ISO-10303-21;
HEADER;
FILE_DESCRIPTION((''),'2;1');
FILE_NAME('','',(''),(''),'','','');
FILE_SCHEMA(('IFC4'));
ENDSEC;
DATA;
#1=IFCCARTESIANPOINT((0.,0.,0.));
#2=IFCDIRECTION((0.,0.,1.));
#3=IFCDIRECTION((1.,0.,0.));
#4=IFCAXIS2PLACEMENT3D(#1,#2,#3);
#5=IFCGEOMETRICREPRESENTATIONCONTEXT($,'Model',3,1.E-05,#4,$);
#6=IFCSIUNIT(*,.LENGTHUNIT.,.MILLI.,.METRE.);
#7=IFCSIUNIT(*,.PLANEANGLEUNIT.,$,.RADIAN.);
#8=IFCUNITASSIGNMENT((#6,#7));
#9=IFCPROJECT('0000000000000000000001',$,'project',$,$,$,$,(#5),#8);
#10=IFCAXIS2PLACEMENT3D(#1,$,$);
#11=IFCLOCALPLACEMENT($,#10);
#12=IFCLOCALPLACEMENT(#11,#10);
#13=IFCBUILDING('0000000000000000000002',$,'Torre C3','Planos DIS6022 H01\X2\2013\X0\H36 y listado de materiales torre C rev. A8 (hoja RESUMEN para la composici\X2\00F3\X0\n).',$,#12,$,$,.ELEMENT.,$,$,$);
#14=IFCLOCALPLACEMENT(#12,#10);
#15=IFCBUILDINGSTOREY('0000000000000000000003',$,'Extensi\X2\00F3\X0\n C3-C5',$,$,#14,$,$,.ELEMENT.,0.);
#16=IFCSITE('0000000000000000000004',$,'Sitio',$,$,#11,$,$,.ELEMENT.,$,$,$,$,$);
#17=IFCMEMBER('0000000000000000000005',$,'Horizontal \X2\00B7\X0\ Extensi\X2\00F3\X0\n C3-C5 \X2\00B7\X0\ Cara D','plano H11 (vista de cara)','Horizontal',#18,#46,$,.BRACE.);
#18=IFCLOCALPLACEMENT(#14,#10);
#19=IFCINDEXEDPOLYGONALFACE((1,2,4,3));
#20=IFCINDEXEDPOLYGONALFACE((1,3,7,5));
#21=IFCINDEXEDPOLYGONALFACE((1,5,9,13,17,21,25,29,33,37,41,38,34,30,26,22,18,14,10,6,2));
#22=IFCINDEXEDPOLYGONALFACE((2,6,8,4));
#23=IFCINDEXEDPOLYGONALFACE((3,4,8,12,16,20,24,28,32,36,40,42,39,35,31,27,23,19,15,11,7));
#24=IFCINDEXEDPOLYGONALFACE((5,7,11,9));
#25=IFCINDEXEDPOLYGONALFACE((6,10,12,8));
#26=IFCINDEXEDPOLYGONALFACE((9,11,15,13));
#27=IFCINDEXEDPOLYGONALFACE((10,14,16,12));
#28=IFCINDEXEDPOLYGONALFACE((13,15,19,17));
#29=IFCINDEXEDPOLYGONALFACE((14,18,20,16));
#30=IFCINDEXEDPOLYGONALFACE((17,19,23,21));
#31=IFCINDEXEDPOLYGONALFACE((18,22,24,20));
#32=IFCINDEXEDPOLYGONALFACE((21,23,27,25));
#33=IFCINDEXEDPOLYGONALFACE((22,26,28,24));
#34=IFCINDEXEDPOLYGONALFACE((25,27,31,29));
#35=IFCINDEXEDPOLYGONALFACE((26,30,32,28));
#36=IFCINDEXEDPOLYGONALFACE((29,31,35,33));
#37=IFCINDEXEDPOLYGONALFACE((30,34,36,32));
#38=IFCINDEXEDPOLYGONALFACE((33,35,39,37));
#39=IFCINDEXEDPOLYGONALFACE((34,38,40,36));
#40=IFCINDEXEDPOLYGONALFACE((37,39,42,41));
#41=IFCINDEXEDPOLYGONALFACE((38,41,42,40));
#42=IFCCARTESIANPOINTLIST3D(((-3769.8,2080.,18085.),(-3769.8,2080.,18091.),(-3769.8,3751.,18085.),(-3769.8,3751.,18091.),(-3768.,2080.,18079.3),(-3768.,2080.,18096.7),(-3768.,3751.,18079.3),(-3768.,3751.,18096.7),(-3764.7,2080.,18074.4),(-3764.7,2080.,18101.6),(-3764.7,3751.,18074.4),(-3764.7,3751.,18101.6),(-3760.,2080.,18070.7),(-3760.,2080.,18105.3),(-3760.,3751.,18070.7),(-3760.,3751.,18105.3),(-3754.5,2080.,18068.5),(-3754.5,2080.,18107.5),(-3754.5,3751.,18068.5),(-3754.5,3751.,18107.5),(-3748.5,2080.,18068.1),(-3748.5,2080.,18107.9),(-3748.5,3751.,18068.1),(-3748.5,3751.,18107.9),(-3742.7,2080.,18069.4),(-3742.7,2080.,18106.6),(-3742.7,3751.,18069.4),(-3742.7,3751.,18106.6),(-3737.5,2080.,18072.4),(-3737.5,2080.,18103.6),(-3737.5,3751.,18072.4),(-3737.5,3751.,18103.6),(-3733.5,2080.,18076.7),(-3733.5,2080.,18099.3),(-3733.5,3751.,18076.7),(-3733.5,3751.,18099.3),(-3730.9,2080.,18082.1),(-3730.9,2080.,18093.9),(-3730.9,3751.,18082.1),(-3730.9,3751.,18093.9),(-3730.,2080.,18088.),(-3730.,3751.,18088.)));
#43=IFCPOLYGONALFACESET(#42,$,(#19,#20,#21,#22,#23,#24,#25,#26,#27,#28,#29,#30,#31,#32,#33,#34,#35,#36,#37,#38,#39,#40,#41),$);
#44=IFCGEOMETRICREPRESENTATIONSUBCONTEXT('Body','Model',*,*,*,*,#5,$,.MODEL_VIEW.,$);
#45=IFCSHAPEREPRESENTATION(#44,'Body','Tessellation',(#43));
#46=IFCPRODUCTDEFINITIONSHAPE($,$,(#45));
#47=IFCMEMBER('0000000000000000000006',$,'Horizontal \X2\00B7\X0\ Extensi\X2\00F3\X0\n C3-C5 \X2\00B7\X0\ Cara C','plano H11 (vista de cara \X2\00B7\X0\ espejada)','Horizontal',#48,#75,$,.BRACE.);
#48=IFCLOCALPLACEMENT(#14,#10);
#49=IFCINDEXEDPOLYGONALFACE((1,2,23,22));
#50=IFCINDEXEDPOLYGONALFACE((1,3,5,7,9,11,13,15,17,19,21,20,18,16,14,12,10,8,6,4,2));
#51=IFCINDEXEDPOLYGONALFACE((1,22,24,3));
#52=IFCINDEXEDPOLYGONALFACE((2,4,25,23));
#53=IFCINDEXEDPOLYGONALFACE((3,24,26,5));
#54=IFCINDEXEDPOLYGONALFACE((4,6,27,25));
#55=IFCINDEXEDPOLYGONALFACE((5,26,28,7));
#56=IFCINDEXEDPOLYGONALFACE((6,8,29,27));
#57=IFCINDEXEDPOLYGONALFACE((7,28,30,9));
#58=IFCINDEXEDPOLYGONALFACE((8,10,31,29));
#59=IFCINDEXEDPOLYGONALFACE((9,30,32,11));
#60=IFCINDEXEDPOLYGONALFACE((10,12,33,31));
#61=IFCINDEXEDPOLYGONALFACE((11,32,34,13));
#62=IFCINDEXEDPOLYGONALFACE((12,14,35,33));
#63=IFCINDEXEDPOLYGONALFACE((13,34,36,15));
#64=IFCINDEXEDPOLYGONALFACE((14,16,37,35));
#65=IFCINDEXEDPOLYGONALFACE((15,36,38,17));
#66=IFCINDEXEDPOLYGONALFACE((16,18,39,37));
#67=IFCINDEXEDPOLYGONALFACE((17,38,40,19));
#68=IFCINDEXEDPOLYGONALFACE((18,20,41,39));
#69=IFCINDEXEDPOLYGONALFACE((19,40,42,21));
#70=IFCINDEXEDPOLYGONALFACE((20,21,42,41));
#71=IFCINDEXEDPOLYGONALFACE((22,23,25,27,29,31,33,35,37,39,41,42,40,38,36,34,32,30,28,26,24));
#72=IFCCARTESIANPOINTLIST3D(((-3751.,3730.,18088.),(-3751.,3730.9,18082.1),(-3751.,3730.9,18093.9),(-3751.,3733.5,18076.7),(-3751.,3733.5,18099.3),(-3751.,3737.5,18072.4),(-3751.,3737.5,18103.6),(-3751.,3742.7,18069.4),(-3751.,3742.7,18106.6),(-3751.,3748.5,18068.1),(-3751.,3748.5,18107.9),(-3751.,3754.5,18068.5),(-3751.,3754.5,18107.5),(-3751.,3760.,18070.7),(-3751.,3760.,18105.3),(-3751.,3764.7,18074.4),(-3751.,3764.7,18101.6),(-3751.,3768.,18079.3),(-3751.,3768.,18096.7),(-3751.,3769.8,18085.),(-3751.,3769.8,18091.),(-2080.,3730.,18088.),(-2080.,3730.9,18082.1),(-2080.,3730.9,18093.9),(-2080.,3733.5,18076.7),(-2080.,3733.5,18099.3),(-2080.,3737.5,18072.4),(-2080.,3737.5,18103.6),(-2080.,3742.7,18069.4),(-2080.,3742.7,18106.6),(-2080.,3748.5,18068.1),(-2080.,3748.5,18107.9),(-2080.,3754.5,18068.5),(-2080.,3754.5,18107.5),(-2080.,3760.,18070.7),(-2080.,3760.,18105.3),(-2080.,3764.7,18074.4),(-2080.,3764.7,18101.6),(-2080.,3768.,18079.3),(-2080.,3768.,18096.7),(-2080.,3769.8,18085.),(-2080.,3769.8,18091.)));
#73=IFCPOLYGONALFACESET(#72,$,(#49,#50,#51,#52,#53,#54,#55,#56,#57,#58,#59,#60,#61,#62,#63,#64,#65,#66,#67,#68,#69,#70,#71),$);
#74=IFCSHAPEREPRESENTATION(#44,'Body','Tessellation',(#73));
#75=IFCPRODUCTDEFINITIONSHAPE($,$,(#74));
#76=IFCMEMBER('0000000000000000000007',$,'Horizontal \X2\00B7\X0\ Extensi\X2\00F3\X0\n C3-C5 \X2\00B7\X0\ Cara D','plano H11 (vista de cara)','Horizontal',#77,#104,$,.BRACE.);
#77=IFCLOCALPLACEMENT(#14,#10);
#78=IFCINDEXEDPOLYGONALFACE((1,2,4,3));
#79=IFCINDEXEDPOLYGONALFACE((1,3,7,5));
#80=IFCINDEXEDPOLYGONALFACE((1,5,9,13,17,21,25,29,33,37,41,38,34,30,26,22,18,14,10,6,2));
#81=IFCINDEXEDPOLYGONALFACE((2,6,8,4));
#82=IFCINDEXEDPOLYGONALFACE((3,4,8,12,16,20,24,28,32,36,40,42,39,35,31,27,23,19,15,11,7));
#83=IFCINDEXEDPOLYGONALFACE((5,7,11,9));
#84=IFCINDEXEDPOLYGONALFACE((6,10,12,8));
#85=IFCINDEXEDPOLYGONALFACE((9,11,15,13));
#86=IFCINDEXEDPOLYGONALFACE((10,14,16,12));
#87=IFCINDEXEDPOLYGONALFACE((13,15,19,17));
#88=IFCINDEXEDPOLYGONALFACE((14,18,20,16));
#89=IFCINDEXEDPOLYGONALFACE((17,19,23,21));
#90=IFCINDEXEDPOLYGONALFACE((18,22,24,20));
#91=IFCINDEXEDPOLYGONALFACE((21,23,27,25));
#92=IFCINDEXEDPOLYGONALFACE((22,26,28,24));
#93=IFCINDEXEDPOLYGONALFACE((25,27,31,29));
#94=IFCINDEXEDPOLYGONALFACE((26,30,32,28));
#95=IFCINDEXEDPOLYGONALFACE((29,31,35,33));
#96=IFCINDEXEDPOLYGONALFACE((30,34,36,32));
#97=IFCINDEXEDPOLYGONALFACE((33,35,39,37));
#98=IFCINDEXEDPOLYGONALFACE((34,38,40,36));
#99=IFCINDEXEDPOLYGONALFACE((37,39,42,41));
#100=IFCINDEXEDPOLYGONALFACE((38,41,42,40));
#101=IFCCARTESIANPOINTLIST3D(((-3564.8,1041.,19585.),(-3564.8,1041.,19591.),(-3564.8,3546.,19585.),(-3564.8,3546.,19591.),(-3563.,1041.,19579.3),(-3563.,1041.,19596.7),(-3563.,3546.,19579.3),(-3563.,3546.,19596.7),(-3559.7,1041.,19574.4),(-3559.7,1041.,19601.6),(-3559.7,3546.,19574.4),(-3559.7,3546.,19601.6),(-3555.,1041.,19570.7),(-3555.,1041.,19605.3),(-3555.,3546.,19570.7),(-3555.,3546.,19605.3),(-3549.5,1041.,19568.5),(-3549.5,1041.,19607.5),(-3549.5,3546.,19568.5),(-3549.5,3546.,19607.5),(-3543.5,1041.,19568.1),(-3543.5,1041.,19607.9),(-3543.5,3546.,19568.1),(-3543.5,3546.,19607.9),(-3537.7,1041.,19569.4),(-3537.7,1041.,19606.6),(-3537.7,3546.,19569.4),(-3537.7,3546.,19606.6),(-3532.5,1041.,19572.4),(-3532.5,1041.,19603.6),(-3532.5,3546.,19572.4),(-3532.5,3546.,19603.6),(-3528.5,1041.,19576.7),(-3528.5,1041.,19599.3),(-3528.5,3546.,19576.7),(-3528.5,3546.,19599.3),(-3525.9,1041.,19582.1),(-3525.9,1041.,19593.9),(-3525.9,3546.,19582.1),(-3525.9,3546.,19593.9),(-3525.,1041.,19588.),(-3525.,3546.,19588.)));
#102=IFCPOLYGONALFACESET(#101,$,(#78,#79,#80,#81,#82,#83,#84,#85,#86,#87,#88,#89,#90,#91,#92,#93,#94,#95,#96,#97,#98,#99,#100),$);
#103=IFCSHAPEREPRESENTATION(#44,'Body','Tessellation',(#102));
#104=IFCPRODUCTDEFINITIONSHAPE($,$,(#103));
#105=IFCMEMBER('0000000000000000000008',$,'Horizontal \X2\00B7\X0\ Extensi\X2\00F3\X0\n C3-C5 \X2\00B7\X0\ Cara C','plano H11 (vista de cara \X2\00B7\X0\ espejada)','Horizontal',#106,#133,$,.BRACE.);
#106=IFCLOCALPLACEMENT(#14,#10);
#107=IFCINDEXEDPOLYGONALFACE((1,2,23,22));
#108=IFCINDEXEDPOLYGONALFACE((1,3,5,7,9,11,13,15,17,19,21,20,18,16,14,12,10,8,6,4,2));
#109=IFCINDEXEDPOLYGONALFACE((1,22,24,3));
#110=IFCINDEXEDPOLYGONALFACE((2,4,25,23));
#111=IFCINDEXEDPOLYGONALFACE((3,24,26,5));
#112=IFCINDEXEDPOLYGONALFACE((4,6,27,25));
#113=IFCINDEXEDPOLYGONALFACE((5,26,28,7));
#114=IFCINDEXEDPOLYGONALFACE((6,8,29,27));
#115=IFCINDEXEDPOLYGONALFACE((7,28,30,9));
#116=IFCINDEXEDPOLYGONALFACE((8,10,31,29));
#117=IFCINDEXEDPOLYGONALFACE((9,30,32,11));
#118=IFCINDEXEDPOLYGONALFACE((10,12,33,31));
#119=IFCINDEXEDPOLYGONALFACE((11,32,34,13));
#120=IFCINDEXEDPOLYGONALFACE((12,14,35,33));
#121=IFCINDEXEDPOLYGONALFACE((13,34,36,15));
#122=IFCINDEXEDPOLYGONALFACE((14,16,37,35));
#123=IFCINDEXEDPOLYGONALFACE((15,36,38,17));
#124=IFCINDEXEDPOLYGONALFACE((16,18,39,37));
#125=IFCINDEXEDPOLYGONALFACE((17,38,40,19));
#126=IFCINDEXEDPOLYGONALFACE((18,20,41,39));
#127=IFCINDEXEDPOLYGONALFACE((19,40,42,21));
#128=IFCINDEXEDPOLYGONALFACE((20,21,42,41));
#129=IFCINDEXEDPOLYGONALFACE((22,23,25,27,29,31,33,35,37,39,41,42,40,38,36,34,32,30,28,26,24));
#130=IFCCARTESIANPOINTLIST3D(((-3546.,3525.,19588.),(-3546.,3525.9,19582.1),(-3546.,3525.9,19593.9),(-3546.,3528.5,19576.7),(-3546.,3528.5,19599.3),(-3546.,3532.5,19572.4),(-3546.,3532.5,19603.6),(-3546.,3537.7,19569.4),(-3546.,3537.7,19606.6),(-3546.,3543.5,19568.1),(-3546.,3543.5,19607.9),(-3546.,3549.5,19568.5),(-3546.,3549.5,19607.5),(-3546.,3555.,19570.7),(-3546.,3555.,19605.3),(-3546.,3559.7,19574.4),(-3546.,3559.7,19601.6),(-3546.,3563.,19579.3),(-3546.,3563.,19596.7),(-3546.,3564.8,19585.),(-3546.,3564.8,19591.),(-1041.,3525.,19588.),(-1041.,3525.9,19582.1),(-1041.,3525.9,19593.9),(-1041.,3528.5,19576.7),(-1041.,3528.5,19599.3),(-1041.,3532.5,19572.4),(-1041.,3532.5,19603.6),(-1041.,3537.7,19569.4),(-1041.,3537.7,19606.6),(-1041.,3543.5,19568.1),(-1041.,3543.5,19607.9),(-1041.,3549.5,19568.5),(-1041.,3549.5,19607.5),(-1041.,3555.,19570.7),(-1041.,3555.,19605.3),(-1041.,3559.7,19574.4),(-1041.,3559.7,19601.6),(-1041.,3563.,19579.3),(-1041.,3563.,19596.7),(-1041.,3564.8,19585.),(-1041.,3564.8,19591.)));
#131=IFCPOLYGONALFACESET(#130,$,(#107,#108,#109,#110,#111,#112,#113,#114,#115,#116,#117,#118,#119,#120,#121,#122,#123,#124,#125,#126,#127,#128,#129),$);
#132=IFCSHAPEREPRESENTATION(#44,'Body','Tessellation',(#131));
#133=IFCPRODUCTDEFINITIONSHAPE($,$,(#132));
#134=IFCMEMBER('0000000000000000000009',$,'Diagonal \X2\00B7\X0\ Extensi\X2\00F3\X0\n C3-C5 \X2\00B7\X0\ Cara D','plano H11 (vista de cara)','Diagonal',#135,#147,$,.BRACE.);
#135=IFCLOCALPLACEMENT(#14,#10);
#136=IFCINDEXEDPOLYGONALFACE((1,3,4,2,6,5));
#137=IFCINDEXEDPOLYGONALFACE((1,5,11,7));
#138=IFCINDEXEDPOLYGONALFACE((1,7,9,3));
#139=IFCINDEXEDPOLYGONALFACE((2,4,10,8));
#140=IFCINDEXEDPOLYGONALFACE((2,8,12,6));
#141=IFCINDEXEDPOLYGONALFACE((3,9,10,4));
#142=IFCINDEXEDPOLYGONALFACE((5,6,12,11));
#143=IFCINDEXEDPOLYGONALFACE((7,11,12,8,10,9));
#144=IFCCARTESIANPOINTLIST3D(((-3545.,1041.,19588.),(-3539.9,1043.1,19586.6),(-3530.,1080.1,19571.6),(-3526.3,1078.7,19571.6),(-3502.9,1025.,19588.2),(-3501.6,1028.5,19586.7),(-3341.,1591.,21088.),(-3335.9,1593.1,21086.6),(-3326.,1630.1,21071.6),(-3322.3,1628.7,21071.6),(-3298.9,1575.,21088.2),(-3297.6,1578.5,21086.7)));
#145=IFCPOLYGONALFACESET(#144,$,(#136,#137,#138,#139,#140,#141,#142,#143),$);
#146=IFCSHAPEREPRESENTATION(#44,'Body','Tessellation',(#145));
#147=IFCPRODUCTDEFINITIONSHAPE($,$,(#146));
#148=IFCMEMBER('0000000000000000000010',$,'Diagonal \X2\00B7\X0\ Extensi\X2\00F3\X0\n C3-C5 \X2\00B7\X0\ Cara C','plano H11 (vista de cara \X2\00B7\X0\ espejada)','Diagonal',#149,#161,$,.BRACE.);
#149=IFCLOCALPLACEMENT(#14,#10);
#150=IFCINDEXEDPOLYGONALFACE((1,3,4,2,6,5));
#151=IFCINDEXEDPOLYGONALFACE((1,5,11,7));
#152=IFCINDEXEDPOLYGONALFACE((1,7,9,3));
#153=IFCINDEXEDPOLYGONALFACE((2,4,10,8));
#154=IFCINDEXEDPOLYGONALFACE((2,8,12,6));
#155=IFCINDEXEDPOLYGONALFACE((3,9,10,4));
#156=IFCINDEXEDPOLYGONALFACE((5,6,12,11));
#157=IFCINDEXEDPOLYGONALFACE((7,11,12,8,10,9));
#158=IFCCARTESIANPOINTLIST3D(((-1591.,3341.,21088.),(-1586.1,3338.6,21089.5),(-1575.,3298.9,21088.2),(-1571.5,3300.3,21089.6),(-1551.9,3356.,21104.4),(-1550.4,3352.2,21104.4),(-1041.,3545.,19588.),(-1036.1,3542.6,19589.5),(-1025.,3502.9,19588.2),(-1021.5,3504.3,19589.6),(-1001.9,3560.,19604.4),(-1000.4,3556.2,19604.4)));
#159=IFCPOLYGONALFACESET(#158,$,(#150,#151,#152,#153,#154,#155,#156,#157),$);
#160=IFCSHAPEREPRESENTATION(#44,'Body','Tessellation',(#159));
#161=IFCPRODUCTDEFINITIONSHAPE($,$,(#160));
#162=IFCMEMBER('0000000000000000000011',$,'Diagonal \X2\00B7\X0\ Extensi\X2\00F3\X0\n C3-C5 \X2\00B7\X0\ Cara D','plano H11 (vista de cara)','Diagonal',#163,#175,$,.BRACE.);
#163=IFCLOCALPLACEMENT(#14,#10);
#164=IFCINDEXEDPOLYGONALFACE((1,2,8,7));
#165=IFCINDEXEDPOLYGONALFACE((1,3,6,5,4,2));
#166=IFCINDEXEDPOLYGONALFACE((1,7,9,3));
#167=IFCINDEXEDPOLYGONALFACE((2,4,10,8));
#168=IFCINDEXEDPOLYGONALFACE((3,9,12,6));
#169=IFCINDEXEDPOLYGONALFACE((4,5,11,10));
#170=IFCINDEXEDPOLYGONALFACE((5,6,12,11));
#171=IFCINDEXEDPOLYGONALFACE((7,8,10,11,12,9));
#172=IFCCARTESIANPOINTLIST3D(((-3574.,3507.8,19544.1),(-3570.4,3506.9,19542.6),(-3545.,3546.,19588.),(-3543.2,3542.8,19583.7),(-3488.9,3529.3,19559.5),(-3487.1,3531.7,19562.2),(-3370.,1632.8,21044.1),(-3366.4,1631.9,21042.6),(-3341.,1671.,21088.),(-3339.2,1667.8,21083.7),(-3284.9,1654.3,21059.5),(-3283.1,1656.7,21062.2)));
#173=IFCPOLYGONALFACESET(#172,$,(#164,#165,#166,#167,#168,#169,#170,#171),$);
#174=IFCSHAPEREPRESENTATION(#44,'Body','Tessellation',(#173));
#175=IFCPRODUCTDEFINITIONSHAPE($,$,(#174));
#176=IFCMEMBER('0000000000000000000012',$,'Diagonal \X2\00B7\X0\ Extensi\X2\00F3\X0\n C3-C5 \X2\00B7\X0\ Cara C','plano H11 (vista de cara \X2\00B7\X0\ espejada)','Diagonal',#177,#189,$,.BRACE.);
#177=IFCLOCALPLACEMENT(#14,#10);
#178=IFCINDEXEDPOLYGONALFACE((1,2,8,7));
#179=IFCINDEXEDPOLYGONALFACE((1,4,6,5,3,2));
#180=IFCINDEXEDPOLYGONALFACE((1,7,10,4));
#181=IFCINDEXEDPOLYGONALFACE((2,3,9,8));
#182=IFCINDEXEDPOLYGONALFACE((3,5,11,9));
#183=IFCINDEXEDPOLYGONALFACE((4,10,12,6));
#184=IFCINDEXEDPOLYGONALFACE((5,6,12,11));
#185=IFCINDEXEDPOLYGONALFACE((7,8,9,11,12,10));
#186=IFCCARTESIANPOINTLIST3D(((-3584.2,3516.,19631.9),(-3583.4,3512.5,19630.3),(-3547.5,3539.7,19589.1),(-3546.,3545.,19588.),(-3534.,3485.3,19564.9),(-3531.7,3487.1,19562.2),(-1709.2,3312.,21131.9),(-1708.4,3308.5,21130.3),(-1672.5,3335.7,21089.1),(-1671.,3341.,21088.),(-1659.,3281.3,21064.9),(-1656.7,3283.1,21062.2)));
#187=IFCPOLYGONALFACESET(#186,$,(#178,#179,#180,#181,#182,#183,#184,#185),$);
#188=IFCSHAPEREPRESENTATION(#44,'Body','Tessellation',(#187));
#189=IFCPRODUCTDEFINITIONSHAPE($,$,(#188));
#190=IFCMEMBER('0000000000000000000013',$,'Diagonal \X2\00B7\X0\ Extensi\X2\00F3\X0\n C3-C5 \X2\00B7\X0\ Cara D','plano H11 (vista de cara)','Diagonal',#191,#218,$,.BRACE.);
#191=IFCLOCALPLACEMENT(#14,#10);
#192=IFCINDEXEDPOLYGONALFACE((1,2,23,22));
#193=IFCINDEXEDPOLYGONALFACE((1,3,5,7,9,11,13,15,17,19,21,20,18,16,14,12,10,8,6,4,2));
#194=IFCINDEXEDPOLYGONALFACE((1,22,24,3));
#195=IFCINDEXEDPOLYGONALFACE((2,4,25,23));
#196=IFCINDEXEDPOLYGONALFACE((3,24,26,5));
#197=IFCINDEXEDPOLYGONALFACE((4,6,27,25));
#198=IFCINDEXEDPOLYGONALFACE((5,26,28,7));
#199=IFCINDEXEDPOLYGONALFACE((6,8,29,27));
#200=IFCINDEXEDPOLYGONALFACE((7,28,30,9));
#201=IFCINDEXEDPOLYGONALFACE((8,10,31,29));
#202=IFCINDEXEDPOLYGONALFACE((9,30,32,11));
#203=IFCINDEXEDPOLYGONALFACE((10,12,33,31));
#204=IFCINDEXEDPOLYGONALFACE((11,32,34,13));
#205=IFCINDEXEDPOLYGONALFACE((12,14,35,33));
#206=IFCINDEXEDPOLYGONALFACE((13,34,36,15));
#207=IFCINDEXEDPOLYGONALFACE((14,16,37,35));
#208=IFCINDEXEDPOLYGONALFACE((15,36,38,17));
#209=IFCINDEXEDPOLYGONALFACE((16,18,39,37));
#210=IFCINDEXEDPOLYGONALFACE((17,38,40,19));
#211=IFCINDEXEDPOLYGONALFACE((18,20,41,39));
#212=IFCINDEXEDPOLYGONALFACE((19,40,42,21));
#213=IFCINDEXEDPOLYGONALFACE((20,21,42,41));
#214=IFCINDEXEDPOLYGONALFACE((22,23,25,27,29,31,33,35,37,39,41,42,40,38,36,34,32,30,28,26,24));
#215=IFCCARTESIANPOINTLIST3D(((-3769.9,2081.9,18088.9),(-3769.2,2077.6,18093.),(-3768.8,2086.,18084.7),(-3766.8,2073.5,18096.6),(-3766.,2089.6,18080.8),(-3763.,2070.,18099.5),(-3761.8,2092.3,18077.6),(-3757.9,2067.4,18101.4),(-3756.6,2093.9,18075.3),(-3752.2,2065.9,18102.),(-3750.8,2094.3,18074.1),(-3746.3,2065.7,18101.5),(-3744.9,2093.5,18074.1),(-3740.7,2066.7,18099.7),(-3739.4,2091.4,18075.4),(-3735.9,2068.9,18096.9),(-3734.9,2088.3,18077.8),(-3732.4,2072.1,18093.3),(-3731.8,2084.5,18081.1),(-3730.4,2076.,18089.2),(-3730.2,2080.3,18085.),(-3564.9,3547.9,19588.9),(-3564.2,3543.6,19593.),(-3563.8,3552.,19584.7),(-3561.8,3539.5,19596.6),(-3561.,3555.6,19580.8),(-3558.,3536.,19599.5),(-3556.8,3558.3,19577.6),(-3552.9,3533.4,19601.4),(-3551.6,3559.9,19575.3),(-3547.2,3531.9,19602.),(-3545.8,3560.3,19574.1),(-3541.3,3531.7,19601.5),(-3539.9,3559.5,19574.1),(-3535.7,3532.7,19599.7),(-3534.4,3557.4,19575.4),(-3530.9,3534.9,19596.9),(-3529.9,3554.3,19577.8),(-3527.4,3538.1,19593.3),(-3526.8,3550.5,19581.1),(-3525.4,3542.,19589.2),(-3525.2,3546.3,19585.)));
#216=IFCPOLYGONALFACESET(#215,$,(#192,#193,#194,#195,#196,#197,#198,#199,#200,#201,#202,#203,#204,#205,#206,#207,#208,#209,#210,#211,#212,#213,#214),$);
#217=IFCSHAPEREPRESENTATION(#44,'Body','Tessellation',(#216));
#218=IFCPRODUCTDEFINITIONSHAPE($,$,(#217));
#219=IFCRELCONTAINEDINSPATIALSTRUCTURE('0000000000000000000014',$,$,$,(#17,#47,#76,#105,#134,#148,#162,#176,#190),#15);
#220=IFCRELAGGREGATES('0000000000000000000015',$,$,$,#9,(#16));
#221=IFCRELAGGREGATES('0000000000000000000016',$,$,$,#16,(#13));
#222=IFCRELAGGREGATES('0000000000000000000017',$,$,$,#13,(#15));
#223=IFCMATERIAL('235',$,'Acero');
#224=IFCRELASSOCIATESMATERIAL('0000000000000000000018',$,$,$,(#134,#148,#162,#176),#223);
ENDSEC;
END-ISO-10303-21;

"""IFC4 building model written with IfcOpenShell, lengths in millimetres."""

from ifc_helpers import new_model, si_unit, frame, frame_2d, origin, origin_with_axes, place, context, subcontext, project, spatial, circle, l_section, extrude, material, element, save


model = new_model("IFC4")

# Units and contexts
model_context = context("Model", 3, precision=1e-05, world=origin_with_axes())
body_context = subcontext(model_context, "Body", "Model", "MODEL_VIEW")
ifc_project = project(units=[si_unit("LENGTHUNIT", "METRE", prefix="MILLI"), si_unit("PLANEANGLEUNIT", "RADIAN")], contexts=[model_context])

# Site, building, storey
site_placement = place(None, origin())
site = spatial("IfcSite", under=ifc_project, at=site_placement, Name="Sitio", CompositionType="ELEMENT")
building_placement = place(site_placement, origin())
building = spatial("IfcBuilding", under=site, at=building_placement, Name="Torre C3", Description="Planos DIS6022 H01–H36 y listado de materiales torre C rev. A8 (hoja RESUMEN para la composición).", CompositionType="ELEMENT")
storey_placement = place(building_placement, origin())
storey = spatial("IfcBuildingStorey", under=building, at=storey_placement, Name="Extensión C3-C5", CompositionType="ELEMENT", Elevation=0.0)

# Members
for number, where, z_axis, x_axis, name, description in (
    (1, (-3750.0, 2080.0, 18088.0), (0.0, 1.0, 0.0), (1.0, 0.0, 0.0), "Horizontal · Extensión C3-C5 · Cara D", "plano H11 (vista de cara)"),
    (2, (-2080.0, 3750.0, 18088.0), (-1.0, 0.0, 0.0), (0.0, -1.0, 0.0), "Horizontal · Extensión C3-C5 · Cara C", "plano H11 (vista de cara · espejada)"),
):
    element("IfcMember", number, at=place(storey_placement, frame(where, z_axis=z_axis, x_axis=x_axis)), inside=storey, Name=name, Description=description, ObjectType="Horizontal", PredefinedType="BRACE", context=body_context, shape_type="SweptSolid", body=[
        extrude(circle(Radius=20.0), None, (0.0, 0.0, 1.0), 1671.0),
    ])
for number, where, z_axis, x_axis, name, description in (
    (3, (-3545.0, 1041.0, 19588.0), (0.0, 1.0, 0.0), (1.0, 0.0, 0.0), "Horizontal · Extensión C3-C5 · Cara D", "plano H11 (vista de cara)"),
    (4, (-1041.0, 3545.0, 19588.0), (-1.0, 0.0, 0.0), (0.0, -1.0, 0.0), "Horizontal · Extensión C3-C5 · Cara C", "plano H11 (vista de cara · espejada)"),
):
    element("IfcMember", number, at=place(storey_placement, frame(where, z_axis=z_axis, x_axis=x_axis)), inside=storey, Name=name, Description=description, ObjectType="Horizontal", PredefinedType="BRACE", context=body_context, shape_type="SweptSolid", body=[
        extrude(circle(Radius=20.0), None, (0.0, 0.0, 1.0), 2505.0),
    ])
ifc_material_1 = material(Name="235", Category="Acero")
for number, where, z_axis, x_axis, name, description in (
    (5, (-3545.0, 1041.0, 19588.0), (0.126659, 0.341482, 0.931315), (0.934555, -0.355803, 0.003362), "Diagonal · Extensión C3-C5 · Cara D", "plano H11 (vista de cara)"),
    (6, (-1041.0, 3545.0, 19588.0), (-0.341482, -0.126659, 0.931315), (0.355803, -0.934555, 0.003362), "Diagonal · Extensión C3-C5 · Cara C", "plano H11 (vista de cara · espejada)"),
):
    element("IfcMember", number, at=place(storey_placement, frame(where, z_axis=z_axis, x_axis=x_axis)), inside=storey, material=ifc_material_1, Name=name, Description=description, ObjectType="Diagonal", PredefinedType="BRACE", context=body_context, shape_type="SweptSolid", body=[
        extrude(l_section(Depth=45.0, Width=45.0, Thickness=4.0, at=frame_2d((22.5, 22.5))), None, (0.0, 0.0, 1.0), 1610.6),
    ])
for number, where, z_axis, x_axis, name, description in (
    (7, (-3341.0, 1671.0, 21088.0), (-0.084654, 0.778066, -0.622453), (0.891172, -0.220307, -0.396583), "Diagonal · Extensión C3-C5 · Cara D", "plano H11 (vista de cara)"),
    (8, (-1671.0, 3341.0, 21088.0), (-0.778066, 0.084654, -0.622453), (0.220307, -0.891172, -0.396583), "Diagonal · Extensión C3-C5 · Cara C", "plano H11 (vista de cara · espejada)"),
):
    element("IfcMember", number, at=place(storey_placement, frame(where, z_axis=z_axis, x_axis=x_axis)), inside=storey, material=ifc_material_1, Name=name, Description=description, ObjectType="Diagonal", PredefinedType="BRACE", context=body_context, shape_type="SweptSolid", body=[
        extrude(l_section(Depth=65.0, Width=65.0, Thickness=4.0, at=frame_2d((32.5, 32.5))), None, (0.0, 0.0, 1.0), 2409.8),
    ])
for number, where, z_axis, x_axis, name in (
    (9, (-3545.0, 3546.0, 19588.0), (-0.097276, -0.69564, -0.711774), (0.880677, -0.39331, 0.264036), "Diagonal · Extensión C3-C5 · Cara D"),
):
    element("IfcMember", number, at=place(storey_placement, frame(where, z_axis=z_axis, x_axis=x_axis)), inside=storey, Name=name, Description="plano H11 (vista de cara)", ObjectType="Diagonal", PredefinedType="BRACE", context=body_context, shape_type="SweptSolid", body=[
        extrude(circle(Radius=20.0), None, (0.0, 0.0, 1.0), 2107.4),
    ])

save(model, "model.ifc")
